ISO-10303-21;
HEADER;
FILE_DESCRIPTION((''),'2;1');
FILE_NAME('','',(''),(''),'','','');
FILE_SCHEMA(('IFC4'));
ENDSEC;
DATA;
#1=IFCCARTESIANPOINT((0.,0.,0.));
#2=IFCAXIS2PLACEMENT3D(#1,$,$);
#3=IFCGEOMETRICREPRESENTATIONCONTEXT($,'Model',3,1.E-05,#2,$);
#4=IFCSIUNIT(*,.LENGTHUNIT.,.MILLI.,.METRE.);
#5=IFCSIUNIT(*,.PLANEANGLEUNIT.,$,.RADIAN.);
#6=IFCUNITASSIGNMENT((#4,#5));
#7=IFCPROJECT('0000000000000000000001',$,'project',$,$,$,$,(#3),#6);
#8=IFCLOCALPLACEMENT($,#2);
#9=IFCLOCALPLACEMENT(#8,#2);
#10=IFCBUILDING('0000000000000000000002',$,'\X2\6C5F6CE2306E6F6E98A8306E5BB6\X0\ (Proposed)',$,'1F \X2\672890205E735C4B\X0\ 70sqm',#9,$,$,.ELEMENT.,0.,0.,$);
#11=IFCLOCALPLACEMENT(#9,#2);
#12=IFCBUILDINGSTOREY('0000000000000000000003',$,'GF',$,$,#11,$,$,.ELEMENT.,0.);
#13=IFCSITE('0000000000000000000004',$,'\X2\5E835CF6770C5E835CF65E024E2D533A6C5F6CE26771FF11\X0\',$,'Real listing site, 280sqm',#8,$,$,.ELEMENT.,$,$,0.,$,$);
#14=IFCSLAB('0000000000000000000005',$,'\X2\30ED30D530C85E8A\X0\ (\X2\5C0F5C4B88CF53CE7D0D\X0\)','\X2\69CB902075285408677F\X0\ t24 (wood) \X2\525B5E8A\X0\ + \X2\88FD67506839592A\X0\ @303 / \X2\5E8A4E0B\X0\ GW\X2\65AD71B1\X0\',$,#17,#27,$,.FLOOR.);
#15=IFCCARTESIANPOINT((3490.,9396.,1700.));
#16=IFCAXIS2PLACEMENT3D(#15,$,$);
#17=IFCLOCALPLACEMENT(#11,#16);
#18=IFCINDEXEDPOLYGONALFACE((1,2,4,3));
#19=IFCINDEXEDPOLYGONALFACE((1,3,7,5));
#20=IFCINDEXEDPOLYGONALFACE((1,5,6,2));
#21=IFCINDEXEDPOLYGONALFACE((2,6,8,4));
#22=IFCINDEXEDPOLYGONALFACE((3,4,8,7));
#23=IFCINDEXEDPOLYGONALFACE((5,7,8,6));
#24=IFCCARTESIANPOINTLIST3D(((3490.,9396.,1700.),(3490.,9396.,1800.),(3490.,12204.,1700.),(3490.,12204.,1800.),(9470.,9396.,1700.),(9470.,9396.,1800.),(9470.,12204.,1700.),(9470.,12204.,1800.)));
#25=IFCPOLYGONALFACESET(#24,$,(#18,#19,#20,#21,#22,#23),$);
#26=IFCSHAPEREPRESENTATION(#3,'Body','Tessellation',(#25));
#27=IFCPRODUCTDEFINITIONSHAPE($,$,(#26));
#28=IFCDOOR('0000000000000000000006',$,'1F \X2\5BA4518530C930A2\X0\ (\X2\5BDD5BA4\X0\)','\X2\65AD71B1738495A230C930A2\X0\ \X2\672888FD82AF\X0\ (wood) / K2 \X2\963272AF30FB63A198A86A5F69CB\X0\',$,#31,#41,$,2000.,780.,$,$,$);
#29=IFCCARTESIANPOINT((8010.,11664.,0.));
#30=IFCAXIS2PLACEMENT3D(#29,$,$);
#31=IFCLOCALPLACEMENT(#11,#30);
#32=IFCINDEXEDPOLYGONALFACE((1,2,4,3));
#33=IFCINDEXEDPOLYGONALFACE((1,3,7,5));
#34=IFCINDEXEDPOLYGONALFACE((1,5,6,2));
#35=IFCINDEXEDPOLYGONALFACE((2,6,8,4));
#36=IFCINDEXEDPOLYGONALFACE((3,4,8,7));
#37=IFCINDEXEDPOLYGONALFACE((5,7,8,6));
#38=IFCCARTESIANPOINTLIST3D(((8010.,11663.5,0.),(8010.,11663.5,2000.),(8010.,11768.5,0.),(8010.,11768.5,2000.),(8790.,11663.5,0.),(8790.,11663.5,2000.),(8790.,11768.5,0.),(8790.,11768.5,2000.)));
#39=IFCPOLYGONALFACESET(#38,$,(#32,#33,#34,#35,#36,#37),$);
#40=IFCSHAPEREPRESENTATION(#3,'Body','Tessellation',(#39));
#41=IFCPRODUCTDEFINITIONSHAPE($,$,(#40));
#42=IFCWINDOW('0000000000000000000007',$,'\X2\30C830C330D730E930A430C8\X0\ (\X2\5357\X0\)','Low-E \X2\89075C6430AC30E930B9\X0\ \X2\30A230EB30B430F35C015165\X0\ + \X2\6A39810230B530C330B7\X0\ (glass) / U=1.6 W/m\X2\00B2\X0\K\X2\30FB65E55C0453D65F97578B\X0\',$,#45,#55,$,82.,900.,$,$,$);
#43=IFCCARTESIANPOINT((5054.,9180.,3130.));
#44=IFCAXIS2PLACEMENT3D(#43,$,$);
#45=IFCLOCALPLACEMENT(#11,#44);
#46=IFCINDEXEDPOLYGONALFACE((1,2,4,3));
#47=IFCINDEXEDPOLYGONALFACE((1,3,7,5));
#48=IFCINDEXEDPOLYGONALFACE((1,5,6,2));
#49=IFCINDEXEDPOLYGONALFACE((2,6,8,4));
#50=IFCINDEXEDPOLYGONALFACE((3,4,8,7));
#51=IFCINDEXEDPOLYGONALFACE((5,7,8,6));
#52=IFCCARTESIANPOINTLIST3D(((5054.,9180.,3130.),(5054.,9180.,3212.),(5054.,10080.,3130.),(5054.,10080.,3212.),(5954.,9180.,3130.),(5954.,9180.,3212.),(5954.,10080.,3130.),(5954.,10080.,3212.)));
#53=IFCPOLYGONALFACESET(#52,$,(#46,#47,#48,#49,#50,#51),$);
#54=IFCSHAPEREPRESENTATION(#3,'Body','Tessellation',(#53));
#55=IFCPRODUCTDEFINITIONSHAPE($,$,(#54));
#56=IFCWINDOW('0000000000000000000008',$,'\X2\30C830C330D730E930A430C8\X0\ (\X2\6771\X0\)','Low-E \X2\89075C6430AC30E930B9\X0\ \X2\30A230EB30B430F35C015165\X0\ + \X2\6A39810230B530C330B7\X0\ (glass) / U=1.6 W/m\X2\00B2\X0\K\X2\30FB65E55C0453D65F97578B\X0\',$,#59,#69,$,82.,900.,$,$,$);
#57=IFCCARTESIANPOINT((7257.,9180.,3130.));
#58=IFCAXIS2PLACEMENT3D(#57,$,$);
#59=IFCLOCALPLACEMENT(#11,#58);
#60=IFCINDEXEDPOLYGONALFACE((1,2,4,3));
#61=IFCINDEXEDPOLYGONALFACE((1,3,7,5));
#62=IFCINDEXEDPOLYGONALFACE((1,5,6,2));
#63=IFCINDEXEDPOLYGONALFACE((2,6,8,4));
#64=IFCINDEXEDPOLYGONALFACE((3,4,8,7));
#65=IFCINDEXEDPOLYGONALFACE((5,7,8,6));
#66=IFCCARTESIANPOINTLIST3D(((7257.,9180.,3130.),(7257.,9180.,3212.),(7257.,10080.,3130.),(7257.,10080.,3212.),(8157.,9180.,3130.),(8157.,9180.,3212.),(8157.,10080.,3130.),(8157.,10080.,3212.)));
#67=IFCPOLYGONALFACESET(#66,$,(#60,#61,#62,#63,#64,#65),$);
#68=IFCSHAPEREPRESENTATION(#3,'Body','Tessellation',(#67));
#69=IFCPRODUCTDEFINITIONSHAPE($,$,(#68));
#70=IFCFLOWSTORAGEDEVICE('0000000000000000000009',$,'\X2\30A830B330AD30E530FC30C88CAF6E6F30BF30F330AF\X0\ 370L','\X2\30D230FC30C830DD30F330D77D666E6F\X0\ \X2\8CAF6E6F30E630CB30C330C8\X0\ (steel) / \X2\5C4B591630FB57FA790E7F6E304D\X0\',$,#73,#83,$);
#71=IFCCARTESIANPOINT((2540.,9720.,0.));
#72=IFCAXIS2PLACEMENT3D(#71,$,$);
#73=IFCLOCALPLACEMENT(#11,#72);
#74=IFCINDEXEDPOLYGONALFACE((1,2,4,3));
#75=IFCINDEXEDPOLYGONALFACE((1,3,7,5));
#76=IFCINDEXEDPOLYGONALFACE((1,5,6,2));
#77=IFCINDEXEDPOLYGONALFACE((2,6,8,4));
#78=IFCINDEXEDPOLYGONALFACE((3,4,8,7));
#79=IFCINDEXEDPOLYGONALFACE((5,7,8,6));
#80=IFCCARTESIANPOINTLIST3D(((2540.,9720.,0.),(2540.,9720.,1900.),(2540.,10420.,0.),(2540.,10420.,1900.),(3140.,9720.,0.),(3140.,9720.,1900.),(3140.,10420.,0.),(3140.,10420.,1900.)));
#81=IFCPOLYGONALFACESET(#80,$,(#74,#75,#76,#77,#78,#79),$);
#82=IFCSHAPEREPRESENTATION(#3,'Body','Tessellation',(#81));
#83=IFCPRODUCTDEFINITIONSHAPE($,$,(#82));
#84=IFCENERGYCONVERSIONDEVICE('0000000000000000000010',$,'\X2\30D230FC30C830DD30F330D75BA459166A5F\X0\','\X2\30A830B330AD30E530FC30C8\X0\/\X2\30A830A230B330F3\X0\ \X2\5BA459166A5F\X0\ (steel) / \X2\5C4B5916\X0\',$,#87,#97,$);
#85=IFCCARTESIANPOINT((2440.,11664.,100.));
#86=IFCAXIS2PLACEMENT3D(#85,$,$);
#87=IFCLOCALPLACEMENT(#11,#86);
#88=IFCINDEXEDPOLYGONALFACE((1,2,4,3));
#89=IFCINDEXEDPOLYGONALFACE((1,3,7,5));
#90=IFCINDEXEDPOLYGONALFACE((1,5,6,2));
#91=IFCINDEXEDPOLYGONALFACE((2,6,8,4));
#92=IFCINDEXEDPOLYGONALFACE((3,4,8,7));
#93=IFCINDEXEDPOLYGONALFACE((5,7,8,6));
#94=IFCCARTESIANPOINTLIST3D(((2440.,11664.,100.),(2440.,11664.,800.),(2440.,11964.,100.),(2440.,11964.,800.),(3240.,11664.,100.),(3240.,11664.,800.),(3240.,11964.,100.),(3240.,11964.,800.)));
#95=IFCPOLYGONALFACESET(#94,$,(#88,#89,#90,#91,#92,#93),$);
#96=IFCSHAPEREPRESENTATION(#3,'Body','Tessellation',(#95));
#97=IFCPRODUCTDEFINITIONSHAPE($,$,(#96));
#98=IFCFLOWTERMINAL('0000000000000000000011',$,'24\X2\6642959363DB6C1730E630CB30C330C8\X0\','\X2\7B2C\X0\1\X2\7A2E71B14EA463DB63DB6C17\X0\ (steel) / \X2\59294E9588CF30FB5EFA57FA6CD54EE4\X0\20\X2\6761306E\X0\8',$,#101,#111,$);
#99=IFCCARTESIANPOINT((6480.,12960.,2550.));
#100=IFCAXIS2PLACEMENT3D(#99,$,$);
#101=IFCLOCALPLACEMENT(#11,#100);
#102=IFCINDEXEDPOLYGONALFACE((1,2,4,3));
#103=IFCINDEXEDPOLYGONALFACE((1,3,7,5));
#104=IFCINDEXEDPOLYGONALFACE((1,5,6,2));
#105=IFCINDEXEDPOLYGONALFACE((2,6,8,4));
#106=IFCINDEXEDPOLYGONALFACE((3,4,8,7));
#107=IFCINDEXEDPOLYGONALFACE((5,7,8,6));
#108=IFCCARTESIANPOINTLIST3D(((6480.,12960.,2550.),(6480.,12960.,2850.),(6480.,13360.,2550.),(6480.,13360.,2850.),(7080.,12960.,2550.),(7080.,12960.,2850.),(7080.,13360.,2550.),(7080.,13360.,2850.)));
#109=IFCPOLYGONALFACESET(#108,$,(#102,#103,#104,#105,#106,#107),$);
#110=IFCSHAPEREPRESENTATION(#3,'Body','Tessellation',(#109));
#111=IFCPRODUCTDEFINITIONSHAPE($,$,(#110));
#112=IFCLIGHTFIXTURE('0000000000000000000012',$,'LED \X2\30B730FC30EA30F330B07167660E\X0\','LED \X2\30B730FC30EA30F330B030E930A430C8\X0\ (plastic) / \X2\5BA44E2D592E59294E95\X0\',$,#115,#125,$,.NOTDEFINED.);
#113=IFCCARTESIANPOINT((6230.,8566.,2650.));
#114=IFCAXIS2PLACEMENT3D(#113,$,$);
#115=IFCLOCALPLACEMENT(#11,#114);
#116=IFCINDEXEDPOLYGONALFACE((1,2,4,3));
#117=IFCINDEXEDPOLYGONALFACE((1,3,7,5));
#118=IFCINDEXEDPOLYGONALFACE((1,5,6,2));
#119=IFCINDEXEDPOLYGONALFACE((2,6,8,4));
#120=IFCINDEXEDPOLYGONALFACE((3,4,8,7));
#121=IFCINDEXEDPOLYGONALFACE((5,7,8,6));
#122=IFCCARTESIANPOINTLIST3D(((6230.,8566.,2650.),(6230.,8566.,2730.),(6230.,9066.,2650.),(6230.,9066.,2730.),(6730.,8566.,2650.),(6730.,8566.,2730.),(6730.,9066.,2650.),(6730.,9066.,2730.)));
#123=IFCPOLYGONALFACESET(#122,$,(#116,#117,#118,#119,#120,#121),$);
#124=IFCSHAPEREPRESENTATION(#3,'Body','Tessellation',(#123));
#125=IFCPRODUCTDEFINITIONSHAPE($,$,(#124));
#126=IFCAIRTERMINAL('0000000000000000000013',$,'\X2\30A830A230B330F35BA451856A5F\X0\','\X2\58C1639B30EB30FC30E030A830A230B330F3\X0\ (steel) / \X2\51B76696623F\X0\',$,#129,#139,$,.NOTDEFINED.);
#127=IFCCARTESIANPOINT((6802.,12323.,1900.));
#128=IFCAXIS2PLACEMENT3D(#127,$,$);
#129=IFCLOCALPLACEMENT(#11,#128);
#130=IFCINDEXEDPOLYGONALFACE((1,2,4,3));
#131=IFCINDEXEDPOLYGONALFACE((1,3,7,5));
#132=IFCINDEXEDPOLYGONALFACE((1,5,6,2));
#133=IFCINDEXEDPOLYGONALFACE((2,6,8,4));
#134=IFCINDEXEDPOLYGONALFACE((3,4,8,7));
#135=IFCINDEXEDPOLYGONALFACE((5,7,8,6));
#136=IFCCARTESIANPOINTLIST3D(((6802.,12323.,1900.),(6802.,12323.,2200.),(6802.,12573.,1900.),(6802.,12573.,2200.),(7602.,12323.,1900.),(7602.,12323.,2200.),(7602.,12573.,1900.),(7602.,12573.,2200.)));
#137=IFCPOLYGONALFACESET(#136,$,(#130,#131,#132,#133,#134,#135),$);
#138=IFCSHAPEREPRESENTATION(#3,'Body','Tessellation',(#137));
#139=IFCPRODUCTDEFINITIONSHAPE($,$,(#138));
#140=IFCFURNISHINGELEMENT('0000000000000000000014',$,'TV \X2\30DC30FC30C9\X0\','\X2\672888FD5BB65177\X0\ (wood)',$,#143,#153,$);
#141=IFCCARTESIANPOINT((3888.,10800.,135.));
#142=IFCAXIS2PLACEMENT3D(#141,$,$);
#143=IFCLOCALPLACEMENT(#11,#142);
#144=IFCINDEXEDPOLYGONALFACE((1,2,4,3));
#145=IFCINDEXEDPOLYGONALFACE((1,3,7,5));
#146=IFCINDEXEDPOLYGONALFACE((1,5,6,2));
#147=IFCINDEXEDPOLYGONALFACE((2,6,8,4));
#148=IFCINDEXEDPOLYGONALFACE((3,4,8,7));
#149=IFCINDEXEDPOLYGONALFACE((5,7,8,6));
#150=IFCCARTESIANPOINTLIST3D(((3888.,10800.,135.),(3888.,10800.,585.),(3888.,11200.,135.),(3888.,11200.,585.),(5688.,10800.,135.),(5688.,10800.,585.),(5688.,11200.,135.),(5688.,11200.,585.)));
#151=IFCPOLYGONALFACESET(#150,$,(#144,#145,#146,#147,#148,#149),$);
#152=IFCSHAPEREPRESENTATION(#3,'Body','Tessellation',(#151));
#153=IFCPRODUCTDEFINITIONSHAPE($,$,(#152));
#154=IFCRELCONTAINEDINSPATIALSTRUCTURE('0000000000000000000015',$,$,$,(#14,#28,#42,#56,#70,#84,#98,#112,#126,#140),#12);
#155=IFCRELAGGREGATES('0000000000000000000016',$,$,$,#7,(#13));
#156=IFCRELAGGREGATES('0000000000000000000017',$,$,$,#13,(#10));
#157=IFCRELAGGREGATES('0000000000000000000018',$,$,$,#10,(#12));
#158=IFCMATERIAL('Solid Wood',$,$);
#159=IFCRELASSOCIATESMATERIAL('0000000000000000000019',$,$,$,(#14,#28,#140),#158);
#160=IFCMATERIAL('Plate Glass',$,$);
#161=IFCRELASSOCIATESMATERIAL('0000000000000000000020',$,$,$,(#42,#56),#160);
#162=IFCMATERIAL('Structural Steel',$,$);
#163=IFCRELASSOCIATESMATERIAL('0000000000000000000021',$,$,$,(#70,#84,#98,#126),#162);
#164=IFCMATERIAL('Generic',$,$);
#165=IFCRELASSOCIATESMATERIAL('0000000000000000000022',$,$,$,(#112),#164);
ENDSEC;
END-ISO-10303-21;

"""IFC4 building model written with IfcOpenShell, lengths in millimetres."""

from ifc_helpers import new_model, si_unit, frame, frame_2d, origin, place, context, project, spatial, rectangle, extrude, material, element, save


model = new_model("IFC4")

# Units and contexts
model_context = context("Model", 3, precision=1e-05, world=origin())
ifc_project = project(units=[si_unit("LENGTHUNIT", "METRE", prefix="MILLI"), si_unit("PLANEANGLEUNIT", "RADIAN")], contexts=[model_context])

# Site, building, storey
site_placement = place(None, origin())
site = spatial("IfcSite", under=ifc_project, at=site_placement, Name="広島県広島市中区江波東１", ObjectType="Real listing site, 280sqm", CompositionType="ELEMENT", RefElevation=0.0)
building_placement = place(site_placement, origin())
building = spatial("IfcBuilding", under=site, at=building_placement, Name="江波の潮風の家 (Proposed)", ObjectType="1F 木造平屋 70sqm", CompositionType="ELEMENT", ElevationOfRefHeight=0.0, ElevationOfTerrain=0.0)
storey_placement = place(building_placement, origin())
storey = spatial("IfcBuildingStorey", under=building, at=storey_placement, Name="GF", CompositionType="ELEMENT", Elevation=0.0)

# Shared definitions
ifc_material_1 = material(Name="Solid Wood")

# Slab
slab_placement = place(storey_placement, frame((3490.0, 9396.0, 1700.0)))
element("IfcSlab", 1, at=slab_placement, inside=storey, material=ifc_material_1, Name="ロフト床 (小屋裏収納)", Description="構造用合板 t24 (wood) 剛床 + 製材根太 @303 / 床下 GW断熱", PredefinedType="FLOOR", context=model_context, shape_type="SweptSolid", body=[
    extrude(rectangle(XDim=5980.0, YDim=2808.0, at=frame_2d((2990.0, 1404.0))), frame((3490.0, 9396.0, 1700.0)), (0.0, 0.0, 1.0), 100.0),
])

# Door
door_1_placement = place(storey_placement, frame((8010.0, 11664.0, 0.0)))
element("IfcDoor", 2, at=door_1_placement, inside=storey, material=ifc_material_1, Name="1F 室内ドア (寝室)", Description="断熱玄関ドア 木製芯 (wood) / K2 防犯・採風機構", OverallHeight=2000.0, OverallWidth=780.0, context=model_context, shape_type="SweptSolid", body=[
    extrude(rectangle(XDim=780.0, YDim=105.0, at=frame_2d((390.0, 52.0))), frame((8010.0, 11664.0, 0.0)), (0.0, 0.0, 1.0), 2000.0),
])

# Windows
ifc_material_2 = material(Name="Plate Glass")
window_1_placement = place(storey_placement, frame((5054.0, 9180.0, 3130.0)))
element("IfcWindow", 3, at=window_1_placement, inside=storey, material=ifc_material_2, Name="トップライト (南)", Description="Low-E 複層ガラス アルゴン封入 + 樹脂サッシ (glass) / U=1.6 W/m²K・日射取得型", OverallHeight=82.0, OverallWidth=900.0, context=model_context, shape_type="SweptSolid", body=[
    extrude(rectangle(XDim=900.0, YDim=900.0, at=frame_2d((450.0, 450.0))), frame((5054.0, 9180.0, 3130.0)), (0.0, 0.0, 1.0), 82.0),
])
window_2_placement = place(storey_placement, frame((7257.0, 9180.0, 3130.0)))
element("IfcWindow", 4, at=window_2_placement, inside=storey, material=ifc_material_2, Name="トップライト (東)", Description="Low-E 複層ガラス アルゴン封入 + 樹脂サッシ (glass) / U=1.6 W/m²K・日射取得型", OverallHeight=82.0, OverallWidth=900.0, context=model_context, shape_type="SweptSolid", body=[
    extrude(rectangle(XDim=900.0, YDim=900.0, at=frame_2d((450.0, 450.0))), frame((7257.0, 9180.0, 3130.0)), (0.0, 0.0, 1.0), 82.0),
])

# Flow storage device
ifc_material_3 = material(Name="Structural Steel")
flow_storage_device_placement = place(storey_placement, frame((2540.0, 9720.0, 0.0)))
element("IfcFlowStorageDevice", 5, at=flow_storage_device_placement, inside=storey, material=ifc_material_3, Name="エコキュート貯湯タンク 370L", Description="ヒートポンプ給湯 貯湯ユニット (steel) / 屋外・基礎置き", context=model_context, shape_type="SweptSolid", body=[
    extrude(rectangle(XDim=600.0, YDim=700.0, at=frame_2d((300.0, 350.0))), frame((2540.0, 9720.0, 0.0)), (0.0, 0.0, 1.0), 1900.0),
])

# Energy conversion device
energy_conversion_device_placement = place(storey_placement, frame((2440.0, 11664.0, 100.0)))
element("IfcEnergyConversionDevice", 6, at=energy_conversion_device_placement, inside=storey, material=ifc_material_3, Name="ヒートポンプ室外機", Description="エコキュート/エアコン 室外機 (steel) / 屋外", context=model_context, shape_type="SweptSolid", body=[
    extrude(rectangle(XDim=800.0, YDim=300.0, at=frame_2d((400.0, 150.0))), frame((2440.0, 11664.0, 100.0)), (0.0, 0.0, 1.0), 700.0),
])

# Flow terminal
flow_terminal_placement = place(storey_placement, frame((6480.0, 12960.0, 2550.0)))
element("IfcFlowTerminal", 7, at=flow_terminal_placement, inside=storey, material=ifc_material_3, Name="24時間換気ユニット", Description="第1種熱交換換気 (steel) / 天井裏・建基法令20条の8", context=model_context, shape_type="SweptSolid", body=[
    extrude(rectangle(XDim=600.0, YDim=400.0, at=frame_2d((300.0, 200.0))), frame((6480.0, 12960.0, 2550.0)), (0.0, 0.0, 1.0), 300.0),
])

# Light fixture
ifc_material_4 = material(Name="Generic")
light_fixture_placement = place(storey_placement, frame((6230.0, 8566.0, 2650.0)))
element("IfcLightFixture", 8, at=light_fixture_placement, inside=storey, material=ifc_material_4, Name="LED シーリング照明", Description="LED シーリングライト (plastic) / 室中央天井", PredefinedType="NOTDEFINED", context=model_context, shape_type="SweptSolid", body=[
    extrude(rectangle(XDim=500.0, YDim=500.0, at=frame_2d((250.0, 250.0))), frame((6230.0, 8566.0, 2650.0)), (0.0, 0.0, 1.0), 80.0),
])

# Air terminal
air_terminal_placement = place(storey_placement, frame((6802.0, 12323.0, 1900.0)))
element("IfcAirTerminal", 9, at=air_terminal_placement, inside=storey, material=ifc_material_3, Name="エアコン室内機", Description="壁掛ルームエアコン (steel) / 冷暖房", PredefinedType="NOTDEFINED", context=model_context, shape_type="SweptSolid", body=[
    extrude(rectangle(XDim=800.0, YDim=250.0, at=frame_2d((400.0, 125.0))), frame((6802.0, 12323.0, 1900.0)), (0.0, 0.0, 1.0), 300.0),
])

# Furnishing element
furnishing_placement = place(storey_placement, frame((3888.0, 10800.0, 135.0)))
element("IfcFurnishingElement", 10, at=furnishing_placement, inside=storey, material=ifc_material_1, Name="TV ボード", Description="木製家具 (wood)", context=model_context, shape_type="SweptSolid", body=[
    extrude(rectangle(XDim=1800.0, YDim=400.0, at=frame_2d((900.0, 200.0))), frame((3888.0, 10800.0, 135.0)), (0.0, 0.0, 1.0), 450.0),
])

save(model, "model.ifc")
